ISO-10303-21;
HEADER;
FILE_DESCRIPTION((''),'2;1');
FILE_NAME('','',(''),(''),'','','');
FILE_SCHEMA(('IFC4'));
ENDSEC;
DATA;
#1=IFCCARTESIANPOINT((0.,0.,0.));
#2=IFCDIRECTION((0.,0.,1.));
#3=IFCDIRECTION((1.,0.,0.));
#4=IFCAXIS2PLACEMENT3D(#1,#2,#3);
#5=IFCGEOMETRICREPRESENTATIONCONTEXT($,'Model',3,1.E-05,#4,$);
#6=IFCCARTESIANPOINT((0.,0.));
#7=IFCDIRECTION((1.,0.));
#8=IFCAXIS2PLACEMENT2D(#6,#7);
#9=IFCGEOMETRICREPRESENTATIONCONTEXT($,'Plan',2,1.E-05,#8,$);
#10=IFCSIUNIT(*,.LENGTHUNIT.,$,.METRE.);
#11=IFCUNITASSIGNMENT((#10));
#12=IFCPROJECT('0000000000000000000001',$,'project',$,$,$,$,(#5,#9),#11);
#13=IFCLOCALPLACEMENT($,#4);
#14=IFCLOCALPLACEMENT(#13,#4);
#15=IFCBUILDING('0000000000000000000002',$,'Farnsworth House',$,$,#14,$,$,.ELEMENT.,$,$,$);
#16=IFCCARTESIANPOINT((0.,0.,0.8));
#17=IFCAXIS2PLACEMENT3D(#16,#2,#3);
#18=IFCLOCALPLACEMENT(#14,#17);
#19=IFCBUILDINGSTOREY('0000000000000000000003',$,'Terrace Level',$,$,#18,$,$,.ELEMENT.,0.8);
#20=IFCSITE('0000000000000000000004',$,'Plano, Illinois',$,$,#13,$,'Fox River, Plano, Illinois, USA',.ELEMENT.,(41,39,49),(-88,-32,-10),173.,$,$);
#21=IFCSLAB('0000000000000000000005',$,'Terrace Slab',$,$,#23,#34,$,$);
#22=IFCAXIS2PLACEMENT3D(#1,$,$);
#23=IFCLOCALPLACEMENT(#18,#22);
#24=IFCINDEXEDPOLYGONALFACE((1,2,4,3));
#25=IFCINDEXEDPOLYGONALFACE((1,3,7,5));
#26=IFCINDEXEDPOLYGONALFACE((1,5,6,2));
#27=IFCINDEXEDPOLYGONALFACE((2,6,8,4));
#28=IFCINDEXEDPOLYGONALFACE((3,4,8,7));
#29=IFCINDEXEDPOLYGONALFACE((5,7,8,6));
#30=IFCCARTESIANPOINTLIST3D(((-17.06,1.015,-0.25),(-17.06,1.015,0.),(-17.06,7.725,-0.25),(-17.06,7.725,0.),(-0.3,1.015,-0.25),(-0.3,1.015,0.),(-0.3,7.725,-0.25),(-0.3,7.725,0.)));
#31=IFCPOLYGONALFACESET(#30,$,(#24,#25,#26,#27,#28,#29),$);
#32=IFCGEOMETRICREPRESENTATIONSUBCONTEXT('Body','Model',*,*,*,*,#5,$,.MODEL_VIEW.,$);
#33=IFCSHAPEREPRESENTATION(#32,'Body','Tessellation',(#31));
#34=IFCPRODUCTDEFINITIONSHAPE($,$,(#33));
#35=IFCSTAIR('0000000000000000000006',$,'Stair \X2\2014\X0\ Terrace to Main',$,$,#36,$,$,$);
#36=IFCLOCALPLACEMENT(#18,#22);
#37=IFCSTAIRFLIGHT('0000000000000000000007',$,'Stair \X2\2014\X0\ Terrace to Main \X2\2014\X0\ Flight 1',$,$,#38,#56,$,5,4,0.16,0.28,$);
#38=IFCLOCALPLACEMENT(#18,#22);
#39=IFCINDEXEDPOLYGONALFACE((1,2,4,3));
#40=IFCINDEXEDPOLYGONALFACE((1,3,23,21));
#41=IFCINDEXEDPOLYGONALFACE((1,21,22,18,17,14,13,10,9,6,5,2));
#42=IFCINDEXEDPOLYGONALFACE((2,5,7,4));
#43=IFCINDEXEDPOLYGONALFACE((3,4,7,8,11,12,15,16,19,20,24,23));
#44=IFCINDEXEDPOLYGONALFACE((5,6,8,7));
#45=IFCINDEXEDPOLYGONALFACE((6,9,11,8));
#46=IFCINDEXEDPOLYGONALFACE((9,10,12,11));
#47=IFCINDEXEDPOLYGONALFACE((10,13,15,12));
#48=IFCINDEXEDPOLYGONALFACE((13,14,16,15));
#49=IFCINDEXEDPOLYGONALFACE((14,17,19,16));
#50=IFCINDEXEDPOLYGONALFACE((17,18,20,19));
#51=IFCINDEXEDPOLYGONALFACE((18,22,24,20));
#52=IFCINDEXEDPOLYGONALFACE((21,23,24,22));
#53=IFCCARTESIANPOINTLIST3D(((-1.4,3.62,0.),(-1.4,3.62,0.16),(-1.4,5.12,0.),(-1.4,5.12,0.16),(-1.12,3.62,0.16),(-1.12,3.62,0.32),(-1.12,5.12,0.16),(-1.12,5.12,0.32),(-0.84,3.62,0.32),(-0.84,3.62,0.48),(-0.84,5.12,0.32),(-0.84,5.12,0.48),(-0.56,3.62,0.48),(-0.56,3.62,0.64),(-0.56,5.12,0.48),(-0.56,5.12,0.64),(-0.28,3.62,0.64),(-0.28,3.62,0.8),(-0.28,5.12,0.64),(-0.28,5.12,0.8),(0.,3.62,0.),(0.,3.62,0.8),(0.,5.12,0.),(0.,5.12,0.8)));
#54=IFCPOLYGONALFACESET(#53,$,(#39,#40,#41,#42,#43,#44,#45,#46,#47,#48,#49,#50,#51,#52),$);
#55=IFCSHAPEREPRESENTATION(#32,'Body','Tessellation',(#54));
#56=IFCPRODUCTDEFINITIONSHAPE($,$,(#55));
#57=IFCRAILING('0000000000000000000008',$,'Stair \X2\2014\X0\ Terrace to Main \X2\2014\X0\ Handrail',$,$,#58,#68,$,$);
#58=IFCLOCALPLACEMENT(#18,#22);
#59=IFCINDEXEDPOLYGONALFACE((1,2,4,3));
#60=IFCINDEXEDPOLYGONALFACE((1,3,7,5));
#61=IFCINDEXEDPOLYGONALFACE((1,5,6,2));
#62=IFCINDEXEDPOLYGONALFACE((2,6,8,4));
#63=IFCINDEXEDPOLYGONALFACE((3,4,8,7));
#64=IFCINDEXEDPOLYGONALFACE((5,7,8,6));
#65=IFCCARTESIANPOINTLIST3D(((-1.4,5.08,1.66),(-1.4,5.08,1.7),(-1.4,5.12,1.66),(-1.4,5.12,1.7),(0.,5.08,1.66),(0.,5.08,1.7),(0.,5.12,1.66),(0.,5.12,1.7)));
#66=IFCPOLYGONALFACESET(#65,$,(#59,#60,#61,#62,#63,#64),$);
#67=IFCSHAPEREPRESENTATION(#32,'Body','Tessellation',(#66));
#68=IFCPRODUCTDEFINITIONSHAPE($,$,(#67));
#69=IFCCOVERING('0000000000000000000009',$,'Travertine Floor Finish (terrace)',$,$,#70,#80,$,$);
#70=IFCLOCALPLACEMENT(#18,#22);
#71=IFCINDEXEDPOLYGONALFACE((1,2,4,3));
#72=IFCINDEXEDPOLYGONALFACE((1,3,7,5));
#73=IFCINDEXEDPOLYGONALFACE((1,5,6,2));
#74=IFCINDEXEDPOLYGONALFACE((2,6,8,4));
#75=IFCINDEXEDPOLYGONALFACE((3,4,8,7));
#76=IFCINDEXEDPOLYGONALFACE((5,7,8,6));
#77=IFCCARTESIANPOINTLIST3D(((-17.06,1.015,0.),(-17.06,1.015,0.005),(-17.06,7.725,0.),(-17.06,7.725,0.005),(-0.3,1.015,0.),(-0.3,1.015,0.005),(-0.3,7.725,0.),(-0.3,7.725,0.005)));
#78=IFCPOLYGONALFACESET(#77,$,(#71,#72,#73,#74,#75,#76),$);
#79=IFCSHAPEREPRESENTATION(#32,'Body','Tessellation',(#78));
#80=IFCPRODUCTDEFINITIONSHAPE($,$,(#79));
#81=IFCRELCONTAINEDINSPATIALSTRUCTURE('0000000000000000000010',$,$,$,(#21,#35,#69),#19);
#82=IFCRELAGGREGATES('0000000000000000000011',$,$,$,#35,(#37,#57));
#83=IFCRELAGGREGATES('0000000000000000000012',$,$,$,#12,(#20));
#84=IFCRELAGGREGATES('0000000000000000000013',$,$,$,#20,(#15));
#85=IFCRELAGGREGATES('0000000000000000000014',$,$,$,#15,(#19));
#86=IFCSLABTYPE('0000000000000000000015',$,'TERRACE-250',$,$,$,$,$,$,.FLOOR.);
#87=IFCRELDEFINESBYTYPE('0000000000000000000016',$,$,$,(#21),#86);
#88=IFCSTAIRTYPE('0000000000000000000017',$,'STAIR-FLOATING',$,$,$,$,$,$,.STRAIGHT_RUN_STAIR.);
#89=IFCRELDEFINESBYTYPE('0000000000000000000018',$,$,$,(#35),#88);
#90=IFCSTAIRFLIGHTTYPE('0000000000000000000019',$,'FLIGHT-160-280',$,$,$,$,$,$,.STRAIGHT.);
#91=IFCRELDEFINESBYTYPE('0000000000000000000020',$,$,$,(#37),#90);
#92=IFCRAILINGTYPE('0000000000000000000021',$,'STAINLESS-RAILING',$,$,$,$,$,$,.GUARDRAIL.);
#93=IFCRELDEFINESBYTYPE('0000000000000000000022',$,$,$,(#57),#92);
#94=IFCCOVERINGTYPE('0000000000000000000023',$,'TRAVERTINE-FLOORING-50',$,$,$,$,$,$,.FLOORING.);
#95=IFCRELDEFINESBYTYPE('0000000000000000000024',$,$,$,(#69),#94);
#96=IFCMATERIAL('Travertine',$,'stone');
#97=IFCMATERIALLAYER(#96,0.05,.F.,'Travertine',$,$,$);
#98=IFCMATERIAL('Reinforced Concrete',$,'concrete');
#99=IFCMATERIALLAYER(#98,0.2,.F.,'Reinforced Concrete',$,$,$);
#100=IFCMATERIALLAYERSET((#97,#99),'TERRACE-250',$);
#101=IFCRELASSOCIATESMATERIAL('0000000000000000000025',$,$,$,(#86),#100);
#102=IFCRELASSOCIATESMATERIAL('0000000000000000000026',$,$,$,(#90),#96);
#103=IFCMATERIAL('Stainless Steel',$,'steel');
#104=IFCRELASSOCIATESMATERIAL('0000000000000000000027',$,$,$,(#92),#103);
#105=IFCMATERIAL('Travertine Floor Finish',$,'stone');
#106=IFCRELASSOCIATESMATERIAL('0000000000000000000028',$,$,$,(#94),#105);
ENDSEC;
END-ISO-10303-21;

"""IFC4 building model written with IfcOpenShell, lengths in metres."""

from ifc_helpers import new_model, si_unit, frame, origin_with_axes, origin_2d_with_axis, place, context, subcontext, project, spatial, polyline, rectangle, outline, extrude, material, layer, layer_set, layer_usage, type_object, element, aggregate, save


model = new_model("IFC4")

# Units and contexts
model_context = context("Model", 3, precision=1e-05, world=origin_with_axes())
plan_context = context("Plan", 2, precision=1e-05, world=origin_2d_with_axis())
body_context = subcontext(model_context, "Body", "Model", "MODEL_VIEW")
ifc_project = project(units=[si_unit("LENGTHUNIT", "METRE")], contexts=[model_context, plan_context])

# Site, building, storey
site_placement = place(None, origin_with_axes())
site = spatial("IfcSite", under=ifc_project, at=site_placement, Name="Plano, Illinois", LongName="Fox River, Plano, Illinois, USA", CompositionType="ELEMENT", RefLatitude=(41, 39, 49), RefLongitude=(-88, -32, -10), RefElevation=173.0)
building_placement = place(site_placement, origin_with_axes())
building = spatial("IfcBuilding", under=site, at=building_placement, Name="Farnsworth House", CompositionType="ELEMENT")
storey_placement = place(building_placement, frame((0.0, 0.0, 0.8), z_axis=(0.0, 0.0, 1.0), x_axis=(1.0, 0.0, 0.0)))
storey = spatial("IfcBuildingStorey", under=building, at=storey_placement, Name="Terrace Level", CompositionType="ELEMENT", Elevation=0.8)

# Slab
ifc_material_1 = material(Name="Travertine", Category="stone")
ifc_layer_1 = layer(ifc_material_1, 0.05, ventilated=False, Name="Travertine")
ifc_material_2 = material(Name="Reinforced Concrete", Category="concrete")
ifc_layer_2 = layer(ifc_material_2, 0.2, ventilated=False, Name="Reinforced Concrete")
ifc_layer_set = layer_set([ifc_layer_1, ifc_layer_2], Name="TERRACE-250")
ifc_layer_usage = layer_usage(ifc_layer_set, "AXIS3", "POSITIVE", -0.25)
slab_type = type_object("IfcSlabType", Name="TERRACE-250", PredefinedType="FLOOR", material=ifc_layer_usage)
slab_placement = place(storey_placement, frame((-17.06, 1.015, -0.25), z_axis=(0.0, 0.0, 1.0), x_axis=(1.0, 0.0, 0.0)))
element("IfcSlab", 1, at=slab_placement, inside=storey, type_object=slab_type, Name="Terrace Slab", context=body_context, shape_type="SweptSolid", body=[
    extrude(rectangle(XDim=16.76, YDim=6.71, at=origin_2d_with_axis()), frame((8.38, 3.355, 0.0), z_axis=(0.0, 0.0, 1.0), x_axis=(1.0, 0.0, 0.0)), (0.0, 0.0, 1.0), 0.25),
])

# Stair, stair flight, railing
stair_type = type_object("IfcStairType", Name="STAIR-FLOATING", PredefinedType="STRAIGHT_RUN_STAIR")
stair_placement = place(storey_placement, frame((-1.4, 3.62, 0.0), z_axis=(0.0, 0.0, 1.0), x_axis=(1.0, 0.0, 0.0)))
stair = element("IfcStair", 2, at=stair_placement, inside=storey, type_object=stair_type, Name="Stair — Terrace to Main")
stair_flight_type = type_object("IfcStairFlightType", Name="FLIGHT-160-280", PredefinedType="STRAIGHT", material=ifc_material_1)
stair_flight_placement = place(stair_placement, origin_with_axes())
stair_flight = element("IfcStairFlight", 3, at=stair_flight_placement, type_object=stair_flight_type, Name="Stair — Terrace to Main — Flight 1", NumberOfRisers=5, NumberOfTreads=4, RiserHeight=0.16, TreadLength=0.28, context=body_context, shape_type="SweptSolid", body=[
    extrude(outline(polyline([(0.0, 0.0), (0.0, 0.16), (0.28, 0.16), (0.28, 0.32), (0.56, 0.32), (0.56, 0.48), (0.84, 0.48), (0.84, 0.64), (1.12, 0.64), (1.12, 0.8), (1.4, 0.8), (1.4, 0.0), (0.0, 0.0)])), frame((0.0, 0.0, 0.0), z_axis=(0.0, -1.0, 0.0), x_axis=(1.0, 0.0, 0.0)), (0.0, 0.0, -1.0), 1.5),
])
ifc_material_3 = material(Name="Stainless Steel", Category="steel")
railing_type = type_object("IfcRailingType", Name="STAINLESS-RAILING", PredefinedType="GUARDRAIL", material=ifc_material_3)
railing_placement = place(stair_placement, frame((0.0, 1.46, 1.66), z_axis=(0.0, 0.0, 1.0), x_axis=(1.0, 0.0, 0.0)))
railing = element("IfcRailing", 4, at=railing_placement, type_object=railing_type, Name="Stair — Terrace to Main — Handrail", context=body_context, shape_type="SweptSolid", body=[
    extrude(rectangle(XDim=1.4, YDim=0.04, at=origin_2d_with_axis()), frame((0.7, 0.02, 0.0), z_axis=(0.0, 0.0, 1.0), x_axis=(1.0, 0.0, 0.0)), (0.0, 0.0, 1.0), 0.04),
])
aggregate(stair, [stair_flight, railing])

# Covering
ifc_material_4 = material(Name="Travertine Floor Finish", Category="stone")
covering_type = type_object("IfcCoveringType", Name="TRAVERTINE-FLOORING-50", PredefinedType="FLOORING", material=ifc_material_4)
covering_placement = place(storey_placement, frame((-17.06, 1.015, 0.0), z_axis=(0.0, 0.0, 1.0), x_axis=(1.0, 0.0, 0.0)))
element("IfcCovering", 5, at=covering_placement, inside=storey, type_object=covering_type, Name="Travertine Floor Finish (terrace)", context=body_context, shape_type="SweptSolid", body=[
    extrude(rectangle(XDim=16.76, YDim=6.71, at=origin_2d_with_axis()), frame((8.38, 3.355, 0.0), z_axis=(0.0, 0.0, 1.0), x_axis=(1.0, 0.0, 0.0)), (0.0, 0.0, 1.0), 0.005),
])

save(model, "model.ifc")
